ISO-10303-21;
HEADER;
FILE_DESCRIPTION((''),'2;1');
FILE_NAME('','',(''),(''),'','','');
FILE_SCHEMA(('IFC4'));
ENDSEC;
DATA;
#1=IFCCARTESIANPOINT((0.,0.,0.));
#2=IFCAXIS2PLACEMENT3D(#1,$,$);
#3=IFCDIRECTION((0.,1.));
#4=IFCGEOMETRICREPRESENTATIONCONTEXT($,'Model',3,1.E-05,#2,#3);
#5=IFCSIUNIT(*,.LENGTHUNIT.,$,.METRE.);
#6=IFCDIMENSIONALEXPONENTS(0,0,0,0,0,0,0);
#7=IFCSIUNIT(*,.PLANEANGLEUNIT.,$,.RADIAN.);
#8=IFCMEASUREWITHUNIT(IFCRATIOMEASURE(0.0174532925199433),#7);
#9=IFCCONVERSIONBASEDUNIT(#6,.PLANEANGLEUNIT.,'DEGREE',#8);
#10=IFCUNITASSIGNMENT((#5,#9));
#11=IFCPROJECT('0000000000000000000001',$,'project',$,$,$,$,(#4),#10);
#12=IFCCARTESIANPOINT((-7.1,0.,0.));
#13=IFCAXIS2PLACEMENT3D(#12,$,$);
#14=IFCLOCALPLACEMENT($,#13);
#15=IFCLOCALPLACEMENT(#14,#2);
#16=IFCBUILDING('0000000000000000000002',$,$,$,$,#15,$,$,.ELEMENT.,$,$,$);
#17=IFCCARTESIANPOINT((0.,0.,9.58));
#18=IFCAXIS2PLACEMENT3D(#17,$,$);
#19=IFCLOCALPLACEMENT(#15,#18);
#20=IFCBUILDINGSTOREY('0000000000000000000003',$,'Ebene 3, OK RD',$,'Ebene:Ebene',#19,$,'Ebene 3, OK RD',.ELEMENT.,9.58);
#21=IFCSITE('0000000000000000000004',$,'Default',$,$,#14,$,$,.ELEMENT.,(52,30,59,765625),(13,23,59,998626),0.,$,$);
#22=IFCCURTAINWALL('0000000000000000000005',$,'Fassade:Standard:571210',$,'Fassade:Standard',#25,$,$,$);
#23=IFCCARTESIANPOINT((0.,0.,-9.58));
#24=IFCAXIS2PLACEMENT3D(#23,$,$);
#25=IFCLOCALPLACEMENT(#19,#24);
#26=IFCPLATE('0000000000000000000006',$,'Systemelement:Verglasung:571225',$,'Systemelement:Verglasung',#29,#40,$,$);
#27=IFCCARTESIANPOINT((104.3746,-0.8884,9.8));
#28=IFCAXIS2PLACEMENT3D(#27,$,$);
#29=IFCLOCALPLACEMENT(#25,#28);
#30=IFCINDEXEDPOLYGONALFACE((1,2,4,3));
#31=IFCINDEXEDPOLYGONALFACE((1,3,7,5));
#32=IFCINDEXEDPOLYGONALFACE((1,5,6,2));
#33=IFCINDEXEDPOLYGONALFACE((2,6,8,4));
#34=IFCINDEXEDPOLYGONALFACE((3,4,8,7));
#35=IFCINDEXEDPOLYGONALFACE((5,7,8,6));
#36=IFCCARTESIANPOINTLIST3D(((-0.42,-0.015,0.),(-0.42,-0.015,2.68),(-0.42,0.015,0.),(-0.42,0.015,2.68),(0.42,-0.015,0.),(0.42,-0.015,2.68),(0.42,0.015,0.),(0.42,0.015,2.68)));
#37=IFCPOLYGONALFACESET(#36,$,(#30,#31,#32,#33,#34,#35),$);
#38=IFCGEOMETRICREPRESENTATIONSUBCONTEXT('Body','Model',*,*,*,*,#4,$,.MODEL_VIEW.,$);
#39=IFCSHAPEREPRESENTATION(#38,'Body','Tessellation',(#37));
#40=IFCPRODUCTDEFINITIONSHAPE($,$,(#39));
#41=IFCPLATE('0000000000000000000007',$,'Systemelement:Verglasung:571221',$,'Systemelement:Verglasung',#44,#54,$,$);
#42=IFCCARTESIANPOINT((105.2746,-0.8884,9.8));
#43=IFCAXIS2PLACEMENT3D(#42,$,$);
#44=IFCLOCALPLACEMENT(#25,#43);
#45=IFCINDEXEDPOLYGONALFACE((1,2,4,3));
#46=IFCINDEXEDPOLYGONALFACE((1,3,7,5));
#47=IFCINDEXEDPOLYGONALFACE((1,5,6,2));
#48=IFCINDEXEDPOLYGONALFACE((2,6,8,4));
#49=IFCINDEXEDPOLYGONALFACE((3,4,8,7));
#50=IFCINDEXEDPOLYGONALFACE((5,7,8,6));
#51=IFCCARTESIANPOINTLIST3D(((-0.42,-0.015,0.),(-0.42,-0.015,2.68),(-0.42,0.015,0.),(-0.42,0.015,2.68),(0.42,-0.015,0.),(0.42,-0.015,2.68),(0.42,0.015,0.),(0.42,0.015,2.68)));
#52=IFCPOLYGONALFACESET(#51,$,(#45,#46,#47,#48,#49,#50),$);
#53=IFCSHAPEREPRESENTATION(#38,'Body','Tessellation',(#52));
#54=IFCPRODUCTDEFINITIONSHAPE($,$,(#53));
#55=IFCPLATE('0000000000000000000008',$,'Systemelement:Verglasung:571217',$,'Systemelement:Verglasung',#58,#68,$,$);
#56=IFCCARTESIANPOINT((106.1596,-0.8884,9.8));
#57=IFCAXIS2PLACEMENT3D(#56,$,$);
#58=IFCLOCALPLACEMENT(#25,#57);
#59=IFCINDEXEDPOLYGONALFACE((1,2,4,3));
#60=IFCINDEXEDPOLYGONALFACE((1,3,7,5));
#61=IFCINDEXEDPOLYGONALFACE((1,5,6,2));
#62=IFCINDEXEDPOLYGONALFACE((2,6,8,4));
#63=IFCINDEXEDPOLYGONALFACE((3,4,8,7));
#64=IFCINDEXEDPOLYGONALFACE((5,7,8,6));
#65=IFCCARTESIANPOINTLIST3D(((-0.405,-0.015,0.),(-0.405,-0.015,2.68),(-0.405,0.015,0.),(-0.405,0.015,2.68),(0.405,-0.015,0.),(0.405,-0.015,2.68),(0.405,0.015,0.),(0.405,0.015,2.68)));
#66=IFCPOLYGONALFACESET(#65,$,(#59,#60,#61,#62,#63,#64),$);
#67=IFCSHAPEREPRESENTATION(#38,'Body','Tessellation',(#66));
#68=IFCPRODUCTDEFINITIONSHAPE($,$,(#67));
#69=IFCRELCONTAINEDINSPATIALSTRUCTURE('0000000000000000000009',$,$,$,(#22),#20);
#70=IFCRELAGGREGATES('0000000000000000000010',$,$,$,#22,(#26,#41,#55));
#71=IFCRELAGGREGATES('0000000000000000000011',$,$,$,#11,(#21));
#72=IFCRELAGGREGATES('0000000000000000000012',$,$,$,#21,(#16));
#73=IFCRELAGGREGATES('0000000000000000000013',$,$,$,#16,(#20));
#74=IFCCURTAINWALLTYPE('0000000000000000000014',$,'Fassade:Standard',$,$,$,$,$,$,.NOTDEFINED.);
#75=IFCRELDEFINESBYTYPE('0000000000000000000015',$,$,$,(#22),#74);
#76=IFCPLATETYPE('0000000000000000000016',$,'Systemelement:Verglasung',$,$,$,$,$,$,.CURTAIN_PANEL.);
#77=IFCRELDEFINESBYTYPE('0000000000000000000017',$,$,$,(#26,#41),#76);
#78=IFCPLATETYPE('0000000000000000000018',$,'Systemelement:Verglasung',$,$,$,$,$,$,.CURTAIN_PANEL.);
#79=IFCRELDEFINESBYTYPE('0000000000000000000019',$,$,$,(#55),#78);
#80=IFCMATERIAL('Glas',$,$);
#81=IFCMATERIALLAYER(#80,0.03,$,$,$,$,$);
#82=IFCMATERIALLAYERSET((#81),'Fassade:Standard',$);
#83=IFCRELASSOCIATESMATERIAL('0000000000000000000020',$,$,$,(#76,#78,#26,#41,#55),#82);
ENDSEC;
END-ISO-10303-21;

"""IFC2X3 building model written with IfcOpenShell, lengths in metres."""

from ifc_helpers import new_model, entity, si_unit, converted_unit, direction, frame, origin, origin_2d_with_axis, place, context, subcontext, project, spatial, rectangle, extrude, source, transform, mapped, material, layer, layer_set, layer_usage, type_object, type_shapes, element, aggregate, save


model = new_model("IFC2X3")

# Units and contexts
model_context = context("Model", 3, precision=1e-05, world=origin(), true_north=direction((0.0, 1.0)))
body_context = subcontext(model_context, "Body", "Model", "MODEL_VIEW")
ifc_project = project(units=[si_unit("LENGTHUNIT", "METRE"), converted_unit("PLANEANGLEUNIT", "DEGREE", entity("IfcRatioMeasure", 0.0174532925199433), si_unit("PLANEANGLEUNIT", "RADIAN"), dimensions=[0, 0, 0, 0, 0, 0, 0])], contexts=[model_context])

# Site, building, storey
site_placement = place(None, frame((-7.1, 0.0, 0.0)))
site = spatial("IfcSite", under=ifc_project, at=site_placement, Name="Default", CompositionType="ELEMENT", RefLatitude=(52, 30, 59, 765625), RefLongitude=(13, 23, 59, 998626), RefElevation=0.0)
building_placement = place(site_placement, origin())
building = spatial("IfcBuilding", under=site, at=building_placement, CompositionType="ELEMENT")
storey_placement = place(building_placement, frame((0.0, 0.0, 9.58)))
storey = spatial("IfcBuildingStorey", under=building, at=storey_placement, Name="Ebene 3, OK RD", ObjectType="Ebene:Ebene", LongName="Ebene 3, OK RD", CompositionType="ELEMENT", Elevation=9.58)

# Curtain wall, plates
curtain_wall_type = type_object("IfcCurtainWallType", Name="Fassade:Standard", PredefinedType="NOTDEFINED")
curtain_wall_placement = place(storey_placement, frame((0.0, 0.0, -9.58)))
curtain_wall = element("IfcCurtainWall", 1, at=curtain_wall_placement, inside=storey, type_object=curtain_wall_type, Name="Fassade:Standard:571210", ObjectType="Fassade:Standard")
ifc_material_1 = material(Name="Glas")
ifc_layer_1 = layer(ifc_material_1, 0.03)
ifc_layer_set_1 = layer_set([ifc_layer_1], Name="Fassade:Standard")
ifc_layer_usage_1 = layer_usage(ifc_layer_set_1, "AXIS3", "POSITIVE", 0.0)
plate_type_1 = type_object("IfcPlateType", Name="Systemelement:Verglasung", PredefinedType="CURTAIN_PANEL", material=ifc_layer_set_1)
shared_shape_1 = source(origin(), body_context, "Body", "SweptSolid", [
    extrude(rectangle(XDim=0.03, YDim=0.84, at=origin_2d_with_axis()), frame((0.0, 0.0, 0.0), z_axis=(0.0, 0.0, 1.0), x_axis=(0.0, 1.0, 0.0)), (0.0, 0.0, 1.0), 2.68),
])
type_shapes(plate_type_1, [shared_shape_1])
plate_1_placement = place(curtain_wall_placement, frame((104.3746, -0.8884, 9.8)))
plate_1 = element("IfcPlate", 2, at=plate_1_placement, type_object=plate_type_1, material=ifc_layer_usage_1, Name="Systemelement:Verglasung:571225", ObjectType="Systemelement:Verglasung", context=body_context, shape_type="MappedRepresentation", body=[
    mapped(shared_shape_1, transform((0.0, 0.0, 0.0), scale=1.0)),
])
ifc_layer_usage_2 = layer_usage(ifc_layer_set_1, "AXIS3", "POSITIVE", 0.0)
plate_2_placement = place(curtain_wall_placement, frame((105.2746, -0.8884, 9.8)))
plate_2 = element("IfcPlate", 3, at=plate_2_placement, type_object=plate_type_1, material=ifc_layer_usage_2, Name="Systemelement:Verglasung:571221", ObjectType="Systemelement:Verglasung", context=body_context, shape_type="MappedRepresentation", body=[
    mapped(shared_shape_1, transform((0.0, 0.0, 0.0), scale=1.0)),
])
ifc_layer_usage_3 = layer_usage(ifc_layer_set_1, "AXIS3", "POSITIVE", 0.0)
plate_type_2 = type_object("IfcPlateType", Name="Systemelement:Verglasung", PredefinedType="CURTAIN_PANEL", material=ifc_layer_set_1)
shared_shape_2 = source(origin(), body_context, "Body", "SweptSolid", [
    extrude(rectangle(XDim=0.03, YDim=0.81, at=origin_2d_with_axis()), frame((0.0, 0.0, 0.0), z_axis=(0.0, 0.0, 1.0), x_axis=(0.0, 1.0, 0.0)), (0.0, 0.0, 1.0), 2.68),
])
type_shapes(plate_type_2, [shared_shape_2])
plate_3_placement = place(curtain_wall_placement, frame((106.1596, -0.8884, 9.8)))
plate_3 = element("IfcPlate", 4, at=plate_3_placement, type_object=plate_type_2, material=ifc_layer_usage_3, Name="Systemelement:Verglasung:571217", ObjectType="Systemelement:Verglasung", context=body_context, shape_type="MappedRepresentation", body=[
    mapped(shared_shape_2, transform((0.0, 0.0, 0.0), scale=1.0)),
])
aggregate(curtain_wall, [plate_1, plate_2, plate_3])

save(model, "model.ifc")
